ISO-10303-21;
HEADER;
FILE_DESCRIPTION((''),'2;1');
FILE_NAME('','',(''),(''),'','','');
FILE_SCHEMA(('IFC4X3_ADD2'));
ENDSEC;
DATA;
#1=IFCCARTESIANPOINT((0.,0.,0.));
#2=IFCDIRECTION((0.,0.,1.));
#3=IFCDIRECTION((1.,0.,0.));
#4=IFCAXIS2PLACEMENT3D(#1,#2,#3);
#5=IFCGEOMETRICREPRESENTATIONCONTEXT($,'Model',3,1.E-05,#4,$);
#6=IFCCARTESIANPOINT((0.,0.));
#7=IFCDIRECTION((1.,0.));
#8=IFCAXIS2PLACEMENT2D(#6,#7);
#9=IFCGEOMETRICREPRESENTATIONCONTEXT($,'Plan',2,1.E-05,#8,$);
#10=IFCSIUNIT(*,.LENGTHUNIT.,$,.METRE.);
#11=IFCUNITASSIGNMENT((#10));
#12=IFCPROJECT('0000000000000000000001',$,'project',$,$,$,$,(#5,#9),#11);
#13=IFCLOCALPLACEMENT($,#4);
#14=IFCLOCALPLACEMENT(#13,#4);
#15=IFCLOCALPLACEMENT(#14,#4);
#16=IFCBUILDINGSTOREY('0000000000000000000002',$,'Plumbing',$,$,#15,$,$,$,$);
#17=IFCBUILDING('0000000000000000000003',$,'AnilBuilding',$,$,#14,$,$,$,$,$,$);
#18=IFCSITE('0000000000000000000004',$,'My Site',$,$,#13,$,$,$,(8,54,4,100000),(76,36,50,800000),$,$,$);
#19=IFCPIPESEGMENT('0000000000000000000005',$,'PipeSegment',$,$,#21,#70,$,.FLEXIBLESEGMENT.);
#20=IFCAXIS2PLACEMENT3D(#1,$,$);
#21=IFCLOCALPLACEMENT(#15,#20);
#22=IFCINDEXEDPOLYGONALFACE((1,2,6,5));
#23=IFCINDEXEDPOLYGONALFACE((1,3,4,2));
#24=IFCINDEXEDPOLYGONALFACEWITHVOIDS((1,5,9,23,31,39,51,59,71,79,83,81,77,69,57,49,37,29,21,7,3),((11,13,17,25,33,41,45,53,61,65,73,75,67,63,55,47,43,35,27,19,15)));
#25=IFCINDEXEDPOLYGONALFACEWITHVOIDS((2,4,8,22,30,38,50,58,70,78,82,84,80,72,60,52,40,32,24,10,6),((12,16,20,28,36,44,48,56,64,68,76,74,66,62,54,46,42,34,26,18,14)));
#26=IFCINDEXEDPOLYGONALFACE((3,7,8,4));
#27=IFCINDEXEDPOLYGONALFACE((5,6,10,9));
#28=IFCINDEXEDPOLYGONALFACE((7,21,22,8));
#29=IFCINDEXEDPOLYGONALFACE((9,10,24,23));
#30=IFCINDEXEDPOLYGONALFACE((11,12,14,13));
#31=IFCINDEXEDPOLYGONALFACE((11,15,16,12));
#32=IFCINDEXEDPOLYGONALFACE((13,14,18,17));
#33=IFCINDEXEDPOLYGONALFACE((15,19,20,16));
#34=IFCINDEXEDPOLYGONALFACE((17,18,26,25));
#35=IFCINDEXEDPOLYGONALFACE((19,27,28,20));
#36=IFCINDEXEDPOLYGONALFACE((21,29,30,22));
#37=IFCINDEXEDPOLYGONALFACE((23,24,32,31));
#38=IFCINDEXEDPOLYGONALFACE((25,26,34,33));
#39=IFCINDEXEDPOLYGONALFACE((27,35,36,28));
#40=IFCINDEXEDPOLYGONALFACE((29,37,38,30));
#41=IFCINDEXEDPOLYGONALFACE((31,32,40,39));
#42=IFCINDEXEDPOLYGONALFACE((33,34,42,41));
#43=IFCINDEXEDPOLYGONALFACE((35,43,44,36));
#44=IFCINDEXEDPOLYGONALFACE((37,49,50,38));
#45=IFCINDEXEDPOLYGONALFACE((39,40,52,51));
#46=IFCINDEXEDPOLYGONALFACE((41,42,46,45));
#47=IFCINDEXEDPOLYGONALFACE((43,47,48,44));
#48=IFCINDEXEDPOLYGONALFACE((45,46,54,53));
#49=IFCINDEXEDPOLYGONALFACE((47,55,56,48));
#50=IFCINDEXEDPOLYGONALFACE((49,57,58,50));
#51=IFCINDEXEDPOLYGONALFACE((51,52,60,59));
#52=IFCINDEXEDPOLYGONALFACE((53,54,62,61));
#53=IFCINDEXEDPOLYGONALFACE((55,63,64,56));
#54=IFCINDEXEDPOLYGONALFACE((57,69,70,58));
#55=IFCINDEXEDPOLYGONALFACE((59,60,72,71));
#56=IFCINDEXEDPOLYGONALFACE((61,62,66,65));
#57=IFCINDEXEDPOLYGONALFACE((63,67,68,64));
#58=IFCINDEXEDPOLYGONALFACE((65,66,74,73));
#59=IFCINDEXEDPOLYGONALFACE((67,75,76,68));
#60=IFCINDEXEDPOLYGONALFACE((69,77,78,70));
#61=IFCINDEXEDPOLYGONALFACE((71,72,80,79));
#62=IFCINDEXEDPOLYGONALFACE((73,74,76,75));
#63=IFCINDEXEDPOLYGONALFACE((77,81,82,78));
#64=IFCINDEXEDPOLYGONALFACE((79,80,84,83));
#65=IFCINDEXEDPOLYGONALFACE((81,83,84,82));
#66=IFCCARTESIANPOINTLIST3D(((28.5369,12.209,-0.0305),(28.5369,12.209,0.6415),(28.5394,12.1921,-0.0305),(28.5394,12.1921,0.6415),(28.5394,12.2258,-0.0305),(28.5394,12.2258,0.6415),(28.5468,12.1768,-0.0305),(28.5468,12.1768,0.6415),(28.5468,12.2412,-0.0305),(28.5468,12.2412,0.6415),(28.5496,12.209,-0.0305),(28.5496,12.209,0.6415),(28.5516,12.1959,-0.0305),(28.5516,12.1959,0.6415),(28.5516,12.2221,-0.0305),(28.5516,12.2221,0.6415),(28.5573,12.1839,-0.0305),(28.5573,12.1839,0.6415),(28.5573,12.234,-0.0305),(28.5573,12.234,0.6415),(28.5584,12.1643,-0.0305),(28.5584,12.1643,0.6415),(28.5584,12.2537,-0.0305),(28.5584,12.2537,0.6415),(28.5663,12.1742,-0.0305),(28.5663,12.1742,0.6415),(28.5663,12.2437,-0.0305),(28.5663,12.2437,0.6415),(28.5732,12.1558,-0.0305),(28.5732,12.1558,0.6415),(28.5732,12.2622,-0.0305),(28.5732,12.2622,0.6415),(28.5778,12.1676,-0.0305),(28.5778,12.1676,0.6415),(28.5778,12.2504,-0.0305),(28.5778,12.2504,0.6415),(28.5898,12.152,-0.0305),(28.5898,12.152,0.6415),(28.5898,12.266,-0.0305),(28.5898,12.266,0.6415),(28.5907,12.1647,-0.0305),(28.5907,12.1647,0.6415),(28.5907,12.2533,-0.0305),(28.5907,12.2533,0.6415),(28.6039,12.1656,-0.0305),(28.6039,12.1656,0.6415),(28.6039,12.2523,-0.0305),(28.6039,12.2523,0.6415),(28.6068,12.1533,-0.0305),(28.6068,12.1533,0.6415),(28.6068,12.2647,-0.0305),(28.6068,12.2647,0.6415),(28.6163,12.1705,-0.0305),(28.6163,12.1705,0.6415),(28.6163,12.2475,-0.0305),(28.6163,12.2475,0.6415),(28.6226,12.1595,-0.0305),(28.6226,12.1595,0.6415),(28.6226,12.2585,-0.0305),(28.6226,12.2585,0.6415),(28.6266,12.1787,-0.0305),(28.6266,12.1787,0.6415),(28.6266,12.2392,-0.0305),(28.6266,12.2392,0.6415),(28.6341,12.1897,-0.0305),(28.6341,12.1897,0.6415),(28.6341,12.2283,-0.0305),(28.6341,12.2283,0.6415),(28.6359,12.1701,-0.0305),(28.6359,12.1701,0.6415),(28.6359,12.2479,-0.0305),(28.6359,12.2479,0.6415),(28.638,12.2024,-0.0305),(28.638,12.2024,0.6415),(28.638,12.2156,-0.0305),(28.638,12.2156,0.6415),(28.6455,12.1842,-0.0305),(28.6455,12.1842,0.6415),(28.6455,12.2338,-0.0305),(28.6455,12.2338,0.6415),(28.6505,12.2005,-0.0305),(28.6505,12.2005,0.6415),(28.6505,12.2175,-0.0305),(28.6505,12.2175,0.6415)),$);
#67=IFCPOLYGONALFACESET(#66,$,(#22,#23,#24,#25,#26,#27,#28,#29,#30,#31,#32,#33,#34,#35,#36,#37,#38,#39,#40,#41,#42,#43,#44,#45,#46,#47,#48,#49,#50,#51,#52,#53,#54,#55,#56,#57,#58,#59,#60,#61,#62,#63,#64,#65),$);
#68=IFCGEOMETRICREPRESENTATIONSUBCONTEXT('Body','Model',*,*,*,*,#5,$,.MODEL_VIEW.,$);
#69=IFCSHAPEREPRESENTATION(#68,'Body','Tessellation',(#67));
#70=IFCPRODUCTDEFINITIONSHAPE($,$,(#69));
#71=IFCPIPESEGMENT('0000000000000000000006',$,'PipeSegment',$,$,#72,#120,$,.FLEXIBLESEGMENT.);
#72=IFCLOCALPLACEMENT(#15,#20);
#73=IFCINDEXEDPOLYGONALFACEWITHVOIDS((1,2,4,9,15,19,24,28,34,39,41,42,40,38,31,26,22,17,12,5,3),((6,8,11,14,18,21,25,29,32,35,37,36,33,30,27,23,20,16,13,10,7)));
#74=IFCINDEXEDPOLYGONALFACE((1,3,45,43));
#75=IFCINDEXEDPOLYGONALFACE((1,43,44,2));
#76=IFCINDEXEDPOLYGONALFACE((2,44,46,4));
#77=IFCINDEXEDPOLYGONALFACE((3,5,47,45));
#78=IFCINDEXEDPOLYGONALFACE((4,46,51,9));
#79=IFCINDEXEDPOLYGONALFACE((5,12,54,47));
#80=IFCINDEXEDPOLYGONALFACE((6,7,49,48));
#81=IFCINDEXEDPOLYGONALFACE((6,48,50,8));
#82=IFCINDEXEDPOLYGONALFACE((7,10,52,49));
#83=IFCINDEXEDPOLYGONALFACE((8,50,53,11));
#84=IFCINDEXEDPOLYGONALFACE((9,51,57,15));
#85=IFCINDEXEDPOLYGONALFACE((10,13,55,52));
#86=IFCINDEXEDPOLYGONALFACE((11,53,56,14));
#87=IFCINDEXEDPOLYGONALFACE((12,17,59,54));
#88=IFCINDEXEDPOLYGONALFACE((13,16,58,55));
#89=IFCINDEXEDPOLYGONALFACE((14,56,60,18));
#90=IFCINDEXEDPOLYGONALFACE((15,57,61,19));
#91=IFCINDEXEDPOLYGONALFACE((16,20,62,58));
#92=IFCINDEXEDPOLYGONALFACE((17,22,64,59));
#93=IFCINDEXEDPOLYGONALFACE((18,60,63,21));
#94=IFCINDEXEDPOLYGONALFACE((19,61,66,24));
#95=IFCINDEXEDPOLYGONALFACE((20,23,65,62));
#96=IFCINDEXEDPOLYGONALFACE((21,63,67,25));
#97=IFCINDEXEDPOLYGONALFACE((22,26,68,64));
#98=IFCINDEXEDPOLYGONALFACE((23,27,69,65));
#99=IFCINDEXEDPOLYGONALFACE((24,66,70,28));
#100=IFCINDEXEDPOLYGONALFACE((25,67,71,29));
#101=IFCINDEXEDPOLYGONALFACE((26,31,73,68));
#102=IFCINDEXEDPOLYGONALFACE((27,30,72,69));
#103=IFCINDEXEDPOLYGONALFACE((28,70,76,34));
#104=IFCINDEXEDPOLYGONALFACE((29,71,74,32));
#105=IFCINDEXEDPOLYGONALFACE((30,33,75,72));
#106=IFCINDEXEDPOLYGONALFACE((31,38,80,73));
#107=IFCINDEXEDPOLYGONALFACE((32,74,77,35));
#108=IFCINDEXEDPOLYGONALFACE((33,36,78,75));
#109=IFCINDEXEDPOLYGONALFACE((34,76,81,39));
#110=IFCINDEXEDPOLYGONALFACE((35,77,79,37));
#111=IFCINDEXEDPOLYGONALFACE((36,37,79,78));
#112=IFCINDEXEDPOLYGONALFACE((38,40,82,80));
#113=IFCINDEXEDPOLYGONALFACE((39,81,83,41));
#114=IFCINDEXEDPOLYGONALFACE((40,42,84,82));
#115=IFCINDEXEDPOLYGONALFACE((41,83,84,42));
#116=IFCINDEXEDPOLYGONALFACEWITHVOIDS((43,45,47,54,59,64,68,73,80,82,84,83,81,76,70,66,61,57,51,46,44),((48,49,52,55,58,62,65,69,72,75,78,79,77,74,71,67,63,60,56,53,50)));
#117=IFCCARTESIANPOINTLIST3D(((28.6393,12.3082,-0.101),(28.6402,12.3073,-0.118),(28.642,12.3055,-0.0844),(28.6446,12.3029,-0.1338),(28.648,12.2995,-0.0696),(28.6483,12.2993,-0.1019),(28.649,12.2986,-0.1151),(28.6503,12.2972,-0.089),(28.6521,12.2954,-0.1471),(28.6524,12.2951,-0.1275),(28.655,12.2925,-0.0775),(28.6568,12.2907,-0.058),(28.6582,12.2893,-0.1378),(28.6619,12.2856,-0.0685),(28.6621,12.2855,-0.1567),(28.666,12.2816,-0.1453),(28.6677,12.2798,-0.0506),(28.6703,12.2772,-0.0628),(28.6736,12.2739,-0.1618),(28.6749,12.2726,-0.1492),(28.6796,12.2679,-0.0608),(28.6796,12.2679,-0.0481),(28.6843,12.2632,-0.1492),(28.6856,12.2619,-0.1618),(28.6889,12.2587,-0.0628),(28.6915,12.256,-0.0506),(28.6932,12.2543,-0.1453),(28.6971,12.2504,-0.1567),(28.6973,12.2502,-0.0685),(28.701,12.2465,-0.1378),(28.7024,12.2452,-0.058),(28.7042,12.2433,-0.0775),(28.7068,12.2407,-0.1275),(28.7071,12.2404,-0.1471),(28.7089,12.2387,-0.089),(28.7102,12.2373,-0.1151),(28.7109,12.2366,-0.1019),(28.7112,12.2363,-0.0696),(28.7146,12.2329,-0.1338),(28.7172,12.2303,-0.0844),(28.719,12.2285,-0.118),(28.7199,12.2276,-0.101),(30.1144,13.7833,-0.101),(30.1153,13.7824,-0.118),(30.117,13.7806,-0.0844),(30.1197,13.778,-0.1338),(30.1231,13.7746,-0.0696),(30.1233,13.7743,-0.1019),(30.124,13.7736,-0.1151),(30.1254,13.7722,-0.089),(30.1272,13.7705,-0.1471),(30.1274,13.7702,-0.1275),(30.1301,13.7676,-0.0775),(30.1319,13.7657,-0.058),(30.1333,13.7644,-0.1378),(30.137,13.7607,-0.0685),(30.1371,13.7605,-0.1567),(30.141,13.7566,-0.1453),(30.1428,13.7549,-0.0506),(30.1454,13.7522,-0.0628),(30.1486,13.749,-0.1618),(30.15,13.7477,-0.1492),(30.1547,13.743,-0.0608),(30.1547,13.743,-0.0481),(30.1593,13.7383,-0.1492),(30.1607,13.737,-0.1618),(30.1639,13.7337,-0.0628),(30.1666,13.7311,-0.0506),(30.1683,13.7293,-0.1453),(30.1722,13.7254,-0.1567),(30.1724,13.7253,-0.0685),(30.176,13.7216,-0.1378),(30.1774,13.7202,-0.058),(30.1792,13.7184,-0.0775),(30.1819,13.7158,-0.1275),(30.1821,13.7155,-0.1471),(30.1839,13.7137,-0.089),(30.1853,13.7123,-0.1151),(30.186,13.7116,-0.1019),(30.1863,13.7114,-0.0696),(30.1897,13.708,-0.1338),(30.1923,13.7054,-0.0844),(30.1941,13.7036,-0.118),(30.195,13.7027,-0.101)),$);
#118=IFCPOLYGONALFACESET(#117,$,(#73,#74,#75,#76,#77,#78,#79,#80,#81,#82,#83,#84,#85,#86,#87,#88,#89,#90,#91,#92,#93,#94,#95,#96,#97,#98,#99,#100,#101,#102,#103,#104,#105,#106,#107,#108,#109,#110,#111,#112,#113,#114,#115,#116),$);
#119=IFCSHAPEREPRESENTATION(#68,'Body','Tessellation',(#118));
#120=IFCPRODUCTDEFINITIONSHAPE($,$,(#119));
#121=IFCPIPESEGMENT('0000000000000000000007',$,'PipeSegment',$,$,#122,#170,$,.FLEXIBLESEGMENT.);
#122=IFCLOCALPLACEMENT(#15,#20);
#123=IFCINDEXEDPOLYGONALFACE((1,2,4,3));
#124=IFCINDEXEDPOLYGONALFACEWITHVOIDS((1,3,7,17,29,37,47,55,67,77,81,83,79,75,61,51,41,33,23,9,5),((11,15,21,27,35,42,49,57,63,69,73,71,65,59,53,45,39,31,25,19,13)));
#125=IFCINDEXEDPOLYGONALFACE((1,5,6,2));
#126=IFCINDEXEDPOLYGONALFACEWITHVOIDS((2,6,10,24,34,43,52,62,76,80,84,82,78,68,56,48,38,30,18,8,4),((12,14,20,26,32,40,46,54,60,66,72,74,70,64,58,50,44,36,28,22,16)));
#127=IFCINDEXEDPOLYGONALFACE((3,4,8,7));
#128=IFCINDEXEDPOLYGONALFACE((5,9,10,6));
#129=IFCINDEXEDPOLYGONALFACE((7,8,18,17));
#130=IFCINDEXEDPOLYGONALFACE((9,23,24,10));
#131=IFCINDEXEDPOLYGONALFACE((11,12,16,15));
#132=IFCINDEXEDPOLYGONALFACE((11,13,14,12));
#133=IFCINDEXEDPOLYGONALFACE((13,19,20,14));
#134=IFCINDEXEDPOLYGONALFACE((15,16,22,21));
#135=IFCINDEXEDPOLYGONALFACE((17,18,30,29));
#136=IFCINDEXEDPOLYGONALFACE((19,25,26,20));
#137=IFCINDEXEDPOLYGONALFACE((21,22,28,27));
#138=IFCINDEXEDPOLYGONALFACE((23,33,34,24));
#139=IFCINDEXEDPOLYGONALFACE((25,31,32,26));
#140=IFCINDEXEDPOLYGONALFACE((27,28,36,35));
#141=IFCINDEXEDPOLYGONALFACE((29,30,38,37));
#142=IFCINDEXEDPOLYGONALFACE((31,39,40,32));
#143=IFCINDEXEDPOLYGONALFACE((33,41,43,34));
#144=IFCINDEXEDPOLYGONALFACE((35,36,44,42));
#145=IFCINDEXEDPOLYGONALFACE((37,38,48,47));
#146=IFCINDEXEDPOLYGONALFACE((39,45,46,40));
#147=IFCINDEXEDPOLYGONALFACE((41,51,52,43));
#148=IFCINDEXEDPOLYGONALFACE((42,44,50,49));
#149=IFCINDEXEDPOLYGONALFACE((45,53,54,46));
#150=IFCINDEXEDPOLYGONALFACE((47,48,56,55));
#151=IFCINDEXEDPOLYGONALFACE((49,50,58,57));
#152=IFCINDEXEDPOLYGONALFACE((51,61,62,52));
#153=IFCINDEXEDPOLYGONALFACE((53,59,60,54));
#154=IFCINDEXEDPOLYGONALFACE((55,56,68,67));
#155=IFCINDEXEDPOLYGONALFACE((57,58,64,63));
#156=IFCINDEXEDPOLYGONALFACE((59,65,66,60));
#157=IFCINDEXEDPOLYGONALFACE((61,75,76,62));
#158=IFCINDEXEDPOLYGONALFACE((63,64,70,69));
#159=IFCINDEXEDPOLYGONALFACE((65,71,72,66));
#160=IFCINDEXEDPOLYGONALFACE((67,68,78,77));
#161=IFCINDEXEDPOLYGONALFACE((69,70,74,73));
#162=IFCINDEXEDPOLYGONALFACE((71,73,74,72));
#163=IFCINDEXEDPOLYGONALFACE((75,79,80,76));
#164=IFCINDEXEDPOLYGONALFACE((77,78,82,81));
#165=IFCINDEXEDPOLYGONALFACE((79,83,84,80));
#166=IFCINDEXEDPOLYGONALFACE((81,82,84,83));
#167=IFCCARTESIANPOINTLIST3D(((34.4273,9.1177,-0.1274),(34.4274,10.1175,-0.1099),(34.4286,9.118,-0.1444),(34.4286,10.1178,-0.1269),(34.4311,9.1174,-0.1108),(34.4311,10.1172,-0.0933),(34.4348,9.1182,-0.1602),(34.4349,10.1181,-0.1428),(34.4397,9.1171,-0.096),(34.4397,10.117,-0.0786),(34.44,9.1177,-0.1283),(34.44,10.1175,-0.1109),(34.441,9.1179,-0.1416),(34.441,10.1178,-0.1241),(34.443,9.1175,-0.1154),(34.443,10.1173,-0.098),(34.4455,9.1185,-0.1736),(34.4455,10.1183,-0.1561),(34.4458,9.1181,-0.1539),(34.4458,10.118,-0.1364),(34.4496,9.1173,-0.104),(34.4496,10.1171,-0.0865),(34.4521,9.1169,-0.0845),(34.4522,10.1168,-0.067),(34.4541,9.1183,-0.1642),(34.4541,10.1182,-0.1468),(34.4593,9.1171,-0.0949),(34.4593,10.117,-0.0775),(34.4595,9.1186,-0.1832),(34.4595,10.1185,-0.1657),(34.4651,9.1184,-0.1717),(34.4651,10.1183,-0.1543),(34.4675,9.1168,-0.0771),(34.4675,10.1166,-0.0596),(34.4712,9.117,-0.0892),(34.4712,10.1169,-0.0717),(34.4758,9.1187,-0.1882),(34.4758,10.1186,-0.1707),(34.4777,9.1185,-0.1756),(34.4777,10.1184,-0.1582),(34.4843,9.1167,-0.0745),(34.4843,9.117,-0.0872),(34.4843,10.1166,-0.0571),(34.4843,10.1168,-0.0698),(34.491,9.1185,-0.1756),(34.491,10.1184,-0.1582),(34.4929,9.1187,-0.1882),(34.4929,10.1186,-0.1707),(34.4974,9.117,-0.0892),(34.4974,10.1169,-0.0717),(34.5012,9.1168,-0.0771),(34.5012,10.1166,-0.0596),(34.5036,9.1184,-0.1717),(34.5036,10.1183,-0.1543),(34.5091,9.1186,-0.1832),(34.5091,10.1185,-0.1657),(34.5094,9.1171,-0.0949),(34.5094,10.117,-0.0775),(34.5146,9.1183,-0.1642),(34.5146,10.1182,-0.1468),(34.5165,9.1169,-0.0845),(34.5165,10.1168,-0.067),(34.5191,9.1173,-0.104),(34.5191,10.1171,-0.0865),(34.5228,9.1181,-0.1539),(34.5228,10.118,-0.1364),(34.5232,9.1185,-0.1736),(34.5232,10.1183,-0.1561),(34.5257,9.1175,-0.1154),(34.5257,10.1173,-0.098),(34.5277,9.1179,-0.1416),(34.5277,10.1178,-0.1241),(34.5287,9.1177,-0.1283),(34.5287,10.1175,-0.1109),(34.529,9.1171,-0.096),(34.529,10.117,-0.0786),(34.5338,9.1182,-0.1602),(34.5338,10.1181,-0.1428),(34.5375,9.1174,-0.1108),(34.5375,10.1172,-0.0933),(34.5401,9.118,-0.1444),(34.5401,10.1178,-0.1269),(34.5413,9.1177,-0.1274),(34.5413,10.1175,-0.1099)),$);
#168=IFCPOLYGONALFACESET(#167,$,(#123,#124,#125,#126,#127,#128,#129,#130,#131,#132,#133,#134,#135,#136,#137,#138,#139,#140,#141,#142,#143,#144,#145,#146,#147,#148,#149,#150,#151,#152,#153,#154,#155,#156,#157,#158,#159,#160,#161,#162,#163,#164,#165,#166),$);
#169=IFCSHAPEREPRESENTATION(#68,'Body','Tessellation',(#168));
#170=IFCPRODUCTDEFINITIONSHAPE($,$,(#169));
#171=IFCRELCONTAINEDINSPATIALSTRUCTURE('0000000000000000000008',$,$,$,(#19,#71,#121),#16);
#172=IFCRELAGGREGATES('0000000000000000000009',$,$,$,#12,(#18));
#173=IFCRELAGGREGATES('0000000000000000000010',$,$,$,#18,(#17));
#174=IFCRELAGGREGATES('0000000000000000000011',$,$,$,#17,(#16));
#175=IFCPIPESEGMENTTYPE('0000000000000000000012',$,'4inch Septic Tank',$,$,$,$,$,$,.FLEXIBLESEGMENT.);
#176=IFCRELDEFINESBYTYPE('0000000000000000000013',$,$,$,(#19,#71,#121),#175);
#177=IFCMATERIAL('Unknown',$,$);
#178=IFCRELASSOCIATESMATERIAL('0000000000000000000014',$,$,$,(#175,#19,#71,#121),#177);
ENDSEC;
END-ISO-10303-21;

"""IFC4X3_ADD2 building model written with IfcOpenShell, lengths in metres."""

from ifc_helpers import new_model, si_unit, frame, origin_with_axes, origin_2d_with_axis, place, context, subcontext, project, spatial, hollow_circle, extrude, material, material_profile, profile_set, profile_usage, type_object, element, save


model = new_model("IFC4X3_ADD2")

# Units and contexts
model_context = context("Model", 3, precision=1e-05, world=origin_with_axes())
plan_context = context("Plan", 2, precision=1e-05, world=origin_2d_with_axis())
body_context = subcontext(model_context, "Body", "Model", "MODEL_VIEW")
ifc_project = project(units=[si_unit("LENGTHUNIT", "METRE")], contexts=[model_context, plan_context])

# Site, building, storey
site_placement = place(None, origin_with_axes())
site = spatial("IfcSite", under=ifc_project, at=site_placement, Name="My Site", RefLatitude=(8, 54, 4, 100000), RefLongitude=(76, 36, 50, 800000))
building_placement = place(site_placement, origin_with_axes())
building = spatial("IfcBuilding", under=site, at=building_placement, Name="AnilBuilding")
storey_placement = place(building_placement, origin_with_axes())
storey = spatial("IfcBuildingStorey", under=building, at=storey_placement, Name="Plumbing")

# Pipe segments
ifc_material_1 = material(Name="Unknown")
ifc_material_profile_1 = material_profile(ifc_material_1, hollow_circle(Radius=0.0571, WallThickness=0.0127))
ifc_profile_set_1 = profile_set([ifc_material_profile_1], Name="blackwater")
ifc_profile_usage_1 = profile_usage(ifc_profile_set_1, cardinal=5)
pipe_segment_type_1 = type_object("IfcPipeSegmentType", Name="4inch Septic Tank", PredefinedType="FLEXIBLESEGMENT", material=ifc_profile_set_1)
pipe_segment_1_placement = place(storey_placement, frame((28.594, 12.209, -0.0305), z_axis=(0.0, 0.0, 1.0), x_axis=(-1.0, 0.0, 0.0)))
element("IfcPipeSegment", 1, at=pipe_segment_1_placement, inside=storey, type_object=pipe_segment_type_1, material=ifc_profile_usage_1, Name="PipeSegment", PredefinedType="FLEXIBLESEGMENT", context=body_context, shape_type="SweptSolid", body=[
    extrude(hollow_circle(Radius=0.0571, WallThickness=0.0127), origin_with_axes(), (0.0, 0.0, 1.0), 0.6719),
])
ifc_profile_usage_2 = profile_usage(ifc_profile_set_1, cardinal=5)
pipe_segment_2_placement = place(storey_placement, frame((28.6796, 12.2679, -0.1052), z_axis=(0.707107, 0.707107, 0.0), x_axis=(0.000001, 0.0, 1.0)))
element("IfcPipeSegment", 2, at=pipe_segment_2_placement, inside=storey, type_object=pipe_segment_type_1, material=ifc_profile_usage_2, Name="PipeSegment", PredefinedType="FLEXIBLESEGMENT", context=body_context, shape_type="SweptSolid", body=[
    extrude(hollow_circle(Radius=0.0571, WallThickness=0.0127), origin_with_axes(), (0.0, 0.0, 1.0), 2.086),
])
ifc_profile_usage_3 = profile_usage(ifc_profile_set_1, cardinal=5)
pipe_segment_3_placement = place(storey_placement, frame((34.4843, 10.1176, -0.1142), z_axis=(-0.000007, -0.999848, -0.017452), x_axis=(0.0, -0.017452, 0.999848)))
element("IfcPipeSegment", 3, at=pipe_segment_3_placement, inside=storey, type_object=pipe_segment_type_1, material=ifc_profile_usage_3, Name="PipeSegment", PredefinedType="FLEXIBLESEGMENT", context=body_context, shape_type="SweptSolid", body=[
    extrude(hollow_circle(Radius=0.0571, WallThickness=0.0127), origin_with_axes(), (0.0, 0.0, 1.0), 1.0),
])

save(model, "model.ifc")
